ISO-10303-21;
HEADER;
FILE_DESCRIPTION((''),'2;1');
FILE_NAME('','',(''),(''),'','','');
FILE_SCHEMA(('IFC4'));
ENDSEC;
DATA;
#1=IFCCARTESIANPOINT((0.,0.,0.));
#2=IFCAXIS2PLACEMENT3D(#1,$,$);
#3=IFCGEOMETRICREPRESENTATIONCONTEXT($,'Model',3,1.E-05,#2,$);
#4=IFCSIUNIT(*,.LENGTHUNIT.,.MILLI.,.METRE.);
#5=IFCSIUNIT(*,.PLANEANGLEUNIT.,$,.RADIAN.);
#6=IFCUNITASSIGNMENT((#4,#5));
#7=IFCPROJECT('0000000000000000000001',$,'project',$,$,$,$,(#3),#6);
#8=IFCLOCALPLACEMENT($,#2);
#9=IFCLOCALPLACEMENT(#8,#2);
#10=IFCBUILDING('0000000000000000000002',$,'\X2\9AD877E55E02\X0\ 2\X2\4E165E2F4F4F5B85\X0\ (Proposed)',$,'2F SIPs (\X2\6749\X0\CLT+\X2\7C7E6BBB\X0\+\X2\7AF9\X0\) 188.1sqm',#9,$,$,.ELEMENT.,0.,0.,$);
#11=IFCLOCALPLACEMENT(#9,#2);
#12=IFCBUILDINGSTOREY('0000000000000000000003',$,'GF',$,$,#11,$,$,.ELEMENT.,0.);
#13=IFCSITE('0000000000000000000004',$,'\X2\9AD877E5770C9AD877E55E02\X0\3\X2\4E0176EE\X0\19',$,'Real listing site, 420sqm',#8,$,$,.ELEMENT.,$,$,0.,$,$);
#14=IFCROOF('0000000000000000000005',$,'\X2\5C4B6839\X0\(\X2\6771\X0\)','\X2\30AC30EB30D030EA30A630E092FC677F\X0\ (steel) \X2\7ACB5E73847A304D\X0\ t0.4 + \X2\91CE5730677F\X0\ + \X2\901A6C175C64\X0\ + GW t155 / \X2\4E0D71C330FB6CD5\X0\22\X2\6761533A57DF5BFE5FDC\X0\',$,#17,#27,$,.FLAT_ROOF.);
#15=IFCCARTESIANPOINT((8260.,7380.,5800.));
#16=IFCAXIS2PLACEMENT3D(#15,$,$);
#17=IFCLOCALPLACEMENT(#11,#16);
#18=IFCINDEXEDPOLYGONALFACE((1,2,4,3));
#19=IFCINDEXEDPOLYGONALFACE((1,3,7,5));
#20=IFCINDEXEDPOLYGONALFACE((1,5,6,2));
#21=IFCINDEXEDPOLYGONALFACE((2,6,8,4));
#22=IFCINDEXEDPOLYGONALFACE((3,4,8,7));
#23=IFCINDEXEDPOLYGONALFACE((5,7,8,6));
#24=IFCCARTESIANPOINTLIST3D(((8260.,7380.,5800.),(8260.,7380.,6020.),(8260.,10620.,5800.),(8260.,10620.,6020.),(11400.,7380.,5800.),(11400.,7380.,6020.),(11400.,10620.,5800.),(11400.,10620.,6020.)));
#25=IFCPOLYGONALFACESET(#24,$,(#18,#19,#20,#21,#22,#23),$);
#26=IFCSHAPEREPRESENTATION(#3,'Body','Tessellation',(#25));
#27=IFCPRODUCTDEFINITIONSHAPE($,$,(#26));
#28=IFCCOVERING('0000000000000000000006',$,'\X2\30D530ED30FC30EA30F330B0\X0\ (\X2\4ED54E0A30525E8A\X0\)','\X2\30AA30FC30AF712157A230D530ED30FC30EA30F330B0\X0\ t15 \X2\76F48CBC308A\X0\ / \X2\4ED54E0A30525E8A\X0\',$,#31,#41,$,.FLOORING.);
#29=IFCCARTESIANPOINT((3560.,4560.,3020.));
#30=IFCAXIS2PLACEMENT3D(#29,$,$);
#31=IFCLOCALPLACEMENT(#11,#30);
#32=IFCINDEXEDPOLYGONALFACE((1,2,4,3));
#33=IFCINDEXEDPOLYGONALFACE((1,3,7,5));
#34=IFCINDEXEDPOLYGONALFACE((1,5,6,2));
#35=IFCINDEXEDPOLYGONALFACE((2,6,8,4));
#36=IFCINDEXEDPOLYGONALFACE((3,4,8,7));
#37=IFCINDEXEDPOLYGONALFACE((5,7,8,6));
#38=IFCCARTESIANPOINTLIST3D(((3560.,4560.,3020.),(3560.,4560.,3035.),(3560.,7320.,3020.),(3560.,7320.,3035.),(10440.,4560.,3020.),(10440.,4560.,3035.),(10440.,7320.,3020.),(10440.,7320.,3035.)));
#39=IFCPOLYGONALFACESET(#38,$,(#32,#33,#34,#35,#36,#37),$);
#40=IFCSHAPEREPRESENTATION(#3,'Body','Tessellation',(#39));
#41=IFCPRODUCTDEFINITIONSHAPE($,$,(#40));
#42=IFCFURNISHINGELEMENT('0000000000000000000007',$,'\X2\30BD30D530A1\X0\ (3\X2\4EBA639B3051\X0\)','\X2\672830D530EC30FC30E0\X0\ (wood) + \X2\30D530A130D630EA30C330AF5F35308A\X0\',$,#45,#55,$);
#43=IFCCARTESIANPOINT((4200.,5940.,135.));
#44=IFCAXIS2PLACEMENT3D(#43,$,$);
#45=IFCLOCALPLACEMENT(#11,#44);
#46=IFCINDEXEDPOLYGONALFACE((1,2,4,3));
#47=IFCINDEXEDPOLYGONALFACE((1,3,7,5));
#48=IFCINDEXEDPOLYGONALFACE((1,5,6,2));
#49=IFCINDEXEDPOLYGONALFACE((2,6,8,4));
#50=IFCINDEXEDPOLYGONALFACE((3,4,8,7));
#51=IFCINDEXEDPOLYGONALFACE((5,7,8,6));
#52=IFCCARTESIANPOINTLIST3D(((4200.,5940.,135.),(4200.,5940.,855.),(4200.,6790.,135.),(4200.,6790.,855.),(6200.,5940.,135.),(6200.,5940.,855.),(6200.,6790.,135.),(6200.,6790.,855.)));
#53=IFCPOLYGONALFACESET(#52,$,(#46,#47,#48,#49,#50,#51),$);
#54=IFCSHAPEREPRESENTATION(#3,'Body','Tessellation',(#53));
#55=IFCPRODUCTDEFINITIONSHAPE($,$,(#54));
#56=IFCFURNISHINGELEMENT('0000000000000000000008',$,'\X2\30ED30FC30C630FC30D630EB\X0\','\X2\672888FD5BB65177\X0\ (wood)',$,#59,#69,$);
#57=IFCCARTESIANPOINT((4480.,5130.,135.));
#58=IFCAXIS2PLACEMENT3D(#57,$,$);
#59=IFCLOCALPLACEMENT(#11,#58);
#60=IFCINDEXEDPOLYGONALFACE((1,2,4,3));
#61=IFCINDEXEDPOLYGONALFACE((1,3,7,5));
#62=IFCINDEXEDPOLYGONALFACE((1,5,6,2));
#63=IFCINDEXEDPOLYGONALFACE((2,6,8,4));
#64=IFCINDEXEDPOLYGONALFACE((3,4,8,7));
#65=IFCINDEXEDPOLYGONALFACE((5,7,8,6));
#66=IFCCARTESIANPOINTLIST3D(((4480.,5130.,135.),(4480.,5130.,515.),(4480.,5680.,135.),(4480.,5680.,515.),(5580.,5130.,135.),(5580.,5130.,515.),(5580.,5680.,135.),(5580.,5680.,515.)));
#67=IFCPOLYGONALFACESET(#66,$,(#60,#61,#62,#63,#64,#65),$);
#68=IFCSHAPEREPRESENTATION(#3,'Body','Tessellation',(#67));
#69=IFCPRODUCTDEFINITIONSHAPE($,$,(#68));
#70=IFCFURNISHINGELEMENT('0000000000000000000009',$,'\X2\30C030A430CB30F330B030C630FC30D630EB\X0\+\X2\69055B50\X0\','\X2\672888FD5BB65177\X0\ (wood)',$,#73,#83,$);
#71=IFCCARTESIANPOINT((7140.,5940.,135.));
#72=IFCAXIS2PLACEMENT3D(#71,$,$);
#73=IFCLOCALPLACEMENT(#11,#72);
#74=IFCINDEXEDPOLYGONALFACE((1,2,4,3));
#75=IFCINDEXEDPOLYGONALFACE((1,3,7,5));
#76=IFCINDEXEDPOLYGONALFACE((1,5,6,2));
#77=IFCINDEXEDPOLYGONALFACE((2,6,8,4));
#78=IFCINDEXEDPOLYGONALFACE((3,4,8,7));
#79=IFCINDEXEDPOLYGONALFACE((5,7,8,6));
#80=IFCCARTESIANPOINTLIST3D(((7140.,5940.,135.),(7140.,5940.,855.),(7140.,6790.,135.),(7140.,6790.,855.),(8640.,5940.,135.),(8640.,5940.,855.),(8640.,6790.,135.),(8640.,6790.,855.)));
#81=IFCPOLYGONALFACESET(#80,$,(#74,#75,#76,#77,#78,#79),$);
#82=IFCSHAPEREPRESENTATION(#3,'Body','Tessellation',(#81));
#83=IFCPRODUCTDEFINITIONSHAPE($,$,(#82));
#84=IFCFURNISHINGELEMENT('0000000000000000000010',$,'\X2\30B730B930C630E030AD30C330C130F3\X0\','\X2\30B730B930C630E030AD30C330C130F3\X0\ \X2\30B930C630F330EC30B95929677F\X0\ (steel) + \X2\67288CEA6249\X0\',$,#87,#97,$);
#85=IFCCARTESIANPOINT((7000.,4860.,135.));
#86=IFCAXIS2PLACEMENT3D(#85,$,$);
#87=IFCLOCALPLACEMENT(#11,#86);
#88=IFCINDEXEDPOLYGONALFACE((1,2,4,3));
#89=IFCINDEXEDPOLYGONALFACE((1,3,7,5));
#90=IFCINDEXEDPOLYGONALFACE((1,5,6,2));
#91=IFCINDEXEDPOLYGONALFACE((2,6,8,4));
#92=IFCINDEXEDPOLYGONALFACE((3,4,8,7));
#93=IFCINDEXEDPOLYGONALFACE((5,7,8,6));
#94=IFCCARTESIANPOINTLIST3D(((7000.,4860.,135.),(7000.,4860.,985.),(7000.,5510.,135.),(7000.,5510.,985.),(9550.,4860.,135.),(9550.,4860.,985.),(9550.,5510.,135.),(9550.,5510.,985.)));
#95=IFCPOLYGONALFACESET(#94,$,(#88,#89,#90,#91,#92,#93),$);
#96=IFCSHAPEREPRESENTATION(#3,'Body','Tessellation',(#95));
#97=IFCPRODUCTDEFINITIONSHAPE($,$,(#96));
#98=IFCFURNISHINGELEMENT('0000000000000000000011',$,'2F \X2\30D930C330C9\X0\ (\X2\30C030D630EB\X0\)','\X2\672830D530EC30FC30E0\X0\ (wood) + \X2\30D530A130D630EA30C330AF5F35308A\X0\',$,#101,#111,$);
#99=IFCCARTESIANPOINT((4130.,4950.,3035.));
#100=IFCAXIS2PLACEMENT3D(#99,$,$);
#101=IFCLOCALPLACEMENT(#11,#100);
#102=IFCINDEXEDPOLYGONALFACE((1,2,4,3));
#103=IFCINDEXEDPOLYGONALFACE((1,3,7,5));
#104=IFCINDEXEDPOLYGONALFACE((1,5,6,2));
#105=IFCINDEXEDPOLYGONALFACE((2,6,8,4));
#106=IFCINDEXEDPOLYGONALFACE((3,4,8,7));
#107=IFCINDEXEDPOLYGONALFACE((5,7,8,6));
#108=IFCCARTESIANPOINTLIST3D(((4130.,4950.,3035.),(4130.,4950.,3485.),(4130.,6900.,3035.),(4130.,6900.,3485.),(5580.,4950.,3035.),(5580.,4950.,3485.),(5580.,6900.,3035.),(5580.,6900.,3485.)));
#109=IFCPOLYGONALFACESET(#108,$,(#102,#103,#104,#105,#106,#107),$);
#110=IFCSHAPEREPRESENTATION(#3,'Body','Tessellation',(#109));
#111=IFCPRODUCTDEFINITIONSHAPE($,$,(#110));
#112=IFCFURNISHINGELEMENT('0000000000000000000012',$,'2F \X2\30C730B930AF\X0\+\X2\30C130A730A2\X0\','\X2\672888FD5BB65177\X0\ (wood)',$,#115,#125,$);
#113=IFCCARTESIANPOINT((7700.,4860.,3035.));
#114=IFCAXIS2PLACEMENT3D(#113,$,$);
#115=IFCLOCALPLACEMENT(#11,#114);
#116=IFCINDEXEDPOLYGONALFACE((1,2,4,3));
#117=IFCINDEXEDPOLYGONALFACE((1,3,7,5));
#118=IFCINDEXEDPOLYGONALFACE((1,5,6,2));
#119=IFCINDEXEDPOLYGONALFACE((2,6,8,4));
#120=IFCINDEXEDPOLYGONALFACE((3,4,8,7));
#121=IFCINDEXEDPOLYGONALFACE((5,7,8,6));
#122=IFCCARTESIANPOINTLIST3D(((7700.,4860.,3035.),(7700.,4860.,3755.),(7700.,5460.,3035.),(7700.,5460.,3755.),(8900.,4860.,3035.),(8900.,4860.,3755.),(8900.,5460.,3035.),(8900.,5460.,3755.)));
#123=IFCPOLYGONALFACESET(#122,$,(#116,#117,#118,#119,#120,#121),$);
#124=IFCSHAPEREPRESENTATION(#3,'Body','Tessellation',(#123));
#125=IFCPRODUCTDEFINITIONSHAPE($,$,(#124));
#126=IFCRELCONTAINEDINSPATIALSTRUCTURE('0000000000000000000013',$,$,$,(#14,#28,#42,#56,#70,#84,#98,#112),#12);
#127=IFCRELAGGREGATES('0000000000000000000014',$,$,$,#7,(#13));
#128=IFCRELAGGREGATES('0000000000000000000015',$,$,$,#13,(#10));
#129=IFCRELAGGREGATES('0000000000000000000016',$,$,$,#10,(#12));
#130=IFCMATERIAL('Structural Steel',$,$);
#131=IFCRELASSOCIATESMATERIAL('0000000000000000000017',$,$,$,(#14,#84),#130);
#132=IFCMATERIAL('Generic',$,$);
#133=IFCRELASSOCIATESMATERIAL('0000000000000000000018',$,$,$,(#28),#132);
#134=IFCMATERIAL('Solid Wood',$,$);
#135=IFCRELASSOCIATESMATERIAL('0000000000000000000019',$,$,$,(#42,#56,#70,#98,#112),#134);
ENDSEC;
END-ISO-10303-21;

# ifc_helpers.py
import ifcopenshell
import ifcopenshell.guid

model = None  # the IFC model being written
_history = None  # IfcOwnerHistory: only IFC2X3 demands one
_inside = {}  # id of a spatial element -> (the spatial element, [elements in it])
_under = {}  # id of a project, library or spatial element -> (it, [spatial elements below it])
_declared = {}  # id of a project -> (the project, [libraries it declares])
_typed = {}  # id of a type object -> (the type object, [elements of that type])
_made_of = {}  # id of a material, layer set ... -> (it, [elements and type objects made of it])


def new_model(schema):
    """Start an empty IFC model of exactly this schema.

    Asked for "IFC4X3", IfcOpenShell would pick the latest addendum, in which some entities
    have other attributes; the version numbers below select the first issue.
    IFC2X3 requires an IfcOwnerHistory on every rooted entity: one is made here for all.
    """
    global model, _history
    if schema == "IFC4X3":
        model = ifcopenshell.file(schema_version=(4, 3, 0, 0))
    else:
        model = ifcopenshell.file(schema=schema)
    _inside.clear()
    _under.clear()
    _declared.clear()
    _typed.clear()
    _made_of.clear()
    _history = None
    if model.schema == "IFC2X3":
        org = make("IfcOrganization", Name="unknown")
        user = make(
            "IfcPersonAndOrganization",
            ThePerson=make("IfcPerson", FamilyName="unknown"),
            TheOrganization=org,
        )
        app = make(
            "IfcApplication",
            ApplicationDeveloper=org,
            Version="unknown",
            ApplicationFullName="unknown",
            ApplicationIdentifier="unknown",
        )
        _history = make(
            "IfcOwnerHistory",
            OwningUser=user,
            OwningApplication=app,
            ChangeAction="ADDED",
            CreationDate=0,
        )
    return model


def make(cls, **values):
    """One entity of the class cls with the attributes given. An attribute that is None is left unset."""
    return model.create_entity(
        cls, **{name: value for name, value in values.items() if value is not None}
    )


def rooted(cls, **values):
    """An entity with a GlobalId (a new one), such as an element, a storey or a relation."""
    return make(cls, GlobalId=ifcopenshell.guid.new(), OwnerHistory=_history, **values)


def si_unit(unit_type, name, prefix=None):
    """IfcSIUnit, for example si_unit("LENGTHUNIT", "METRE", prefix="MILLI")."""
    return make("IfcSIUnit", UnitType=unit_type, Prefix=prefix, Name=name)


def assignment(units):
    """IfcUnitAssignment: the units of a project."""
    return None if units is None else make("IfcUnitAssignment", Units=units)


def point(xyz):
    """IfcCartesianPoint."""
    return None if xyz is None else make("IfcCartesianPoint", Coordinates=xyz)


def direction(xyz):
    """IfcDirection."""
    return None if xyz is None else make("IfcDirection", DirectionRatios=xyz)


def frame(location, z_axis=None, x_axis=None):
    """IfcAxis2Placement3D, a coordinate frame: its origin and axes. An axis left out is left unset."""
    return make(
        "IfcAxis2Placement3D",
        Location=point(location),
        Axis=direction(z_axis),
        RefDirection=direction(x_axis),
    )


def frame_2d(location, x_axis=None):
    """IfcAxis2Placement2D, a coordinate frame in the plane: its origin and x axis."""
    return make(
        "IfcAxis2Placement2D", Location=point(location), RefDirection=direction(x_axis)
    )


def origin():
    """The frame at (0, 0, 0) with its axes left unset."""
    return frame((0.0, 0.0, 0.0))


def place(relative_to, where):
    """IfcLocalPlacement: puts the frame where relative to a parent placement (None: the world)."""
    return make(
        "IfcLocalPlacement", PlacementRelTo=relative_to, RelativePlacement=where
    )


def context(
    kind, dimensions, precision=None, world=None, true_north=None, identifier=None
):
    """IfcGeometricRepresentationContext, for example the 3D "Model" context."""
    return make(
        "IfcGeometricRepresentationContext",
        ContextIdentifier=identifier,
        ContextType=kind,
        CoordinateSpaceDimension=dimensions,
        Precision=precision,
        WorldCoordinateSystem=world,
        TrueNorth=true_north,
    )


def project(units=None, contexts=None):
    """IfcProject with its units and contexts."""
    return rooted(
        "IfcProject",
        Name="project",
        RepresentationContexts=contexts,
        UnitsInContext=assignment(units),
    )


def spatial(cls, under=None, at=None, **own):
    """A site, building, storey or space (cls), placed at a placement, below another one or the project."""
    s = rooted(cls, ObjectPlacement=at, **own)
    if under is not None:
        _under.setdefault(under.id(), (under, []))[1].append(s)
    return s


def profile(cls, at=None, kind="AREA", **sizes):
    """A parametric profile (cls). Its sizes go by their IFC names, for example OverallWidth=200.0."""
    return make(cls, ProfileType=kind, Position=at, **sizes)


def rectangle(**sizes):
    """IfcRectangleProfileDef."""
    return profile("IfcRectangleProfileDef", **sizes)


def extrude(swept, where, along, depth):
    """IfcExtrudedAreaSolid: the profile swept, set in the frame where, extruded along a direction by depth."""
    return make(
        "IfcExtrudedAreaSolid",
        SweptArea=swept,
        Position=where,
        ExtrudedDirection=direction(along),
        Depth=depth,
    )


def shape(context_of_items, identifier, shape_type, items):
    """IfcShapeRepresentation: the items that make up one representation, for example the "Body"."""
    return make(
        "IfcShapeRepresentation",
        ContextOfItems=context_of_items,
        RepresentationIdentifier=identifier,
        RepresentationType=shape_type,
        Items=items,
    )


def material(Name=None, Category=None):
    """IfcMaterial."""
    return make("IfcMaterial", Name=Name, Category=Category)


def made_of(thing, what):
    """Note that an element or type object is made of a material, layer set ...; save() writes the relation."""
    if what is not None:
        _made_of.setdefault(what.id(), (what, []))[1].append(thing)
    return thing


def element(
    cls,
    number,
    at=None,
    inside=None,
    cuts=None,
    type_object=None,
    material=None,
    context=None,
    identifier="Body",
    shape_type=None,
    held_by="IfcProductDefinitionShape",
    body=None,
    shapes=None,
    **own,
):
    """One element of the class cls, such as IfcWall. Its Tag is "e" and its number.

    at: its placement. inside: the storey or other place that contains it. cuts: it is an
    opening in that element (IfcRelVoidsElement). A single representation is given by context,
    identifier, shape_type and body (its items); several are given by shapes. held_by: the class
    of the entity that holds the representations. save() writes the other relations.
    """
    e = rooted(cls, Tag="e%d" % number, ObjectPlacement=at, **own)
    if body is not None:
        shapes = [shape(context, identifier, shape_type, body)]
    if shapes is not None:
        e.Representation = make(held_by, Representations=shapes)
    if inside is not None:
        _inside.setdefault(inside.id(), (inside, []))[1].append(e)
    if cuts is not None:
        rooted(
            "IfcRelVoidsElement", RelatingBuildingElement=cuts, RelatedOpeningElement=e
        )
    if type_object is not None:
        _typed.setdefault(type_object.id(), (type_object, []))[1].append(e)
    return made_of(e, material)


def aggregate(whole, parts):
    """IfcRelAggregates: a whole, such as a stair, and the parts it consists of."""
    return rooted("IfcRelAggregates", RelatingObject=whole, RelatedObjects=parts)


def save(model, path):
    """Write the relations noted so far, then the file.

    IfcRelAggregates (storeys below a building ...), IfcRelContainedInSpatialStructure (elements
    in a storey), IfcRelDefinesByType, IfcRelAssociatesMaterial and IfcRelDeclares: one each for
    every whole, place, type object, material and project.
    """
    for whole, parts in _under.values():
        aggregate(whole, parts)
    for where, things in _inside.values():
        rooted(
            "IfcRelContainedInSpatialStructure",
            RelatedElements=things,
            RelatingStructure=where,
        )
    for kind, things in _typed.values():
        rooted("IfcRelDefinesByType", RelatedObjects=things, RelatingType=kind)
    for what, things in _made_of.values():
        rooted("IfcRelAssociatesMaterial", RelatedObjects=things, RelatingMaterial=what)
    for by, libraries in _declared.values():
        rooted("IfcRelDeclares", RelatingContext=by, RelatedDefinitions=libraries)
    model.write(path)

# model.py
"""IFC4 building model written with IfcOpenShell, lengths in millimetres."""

from ifc_helpers import new_model, si_unit, frame, frame_2d, origin, place, context, project, spatial, rectangle, extrude, material, element, save


model = new_model("IFC4")

# Units and contexts
model_context = context("Model", 3, precision=1e-05, world=origin())
ifc_project = project(units=[si_unit("LENGTHUNIT", "METRE", prefix="MILLI"), si_unit("PLANEANGLEUNIT", "RADIAN")], contexts=[model_context])

# Site, building, storey
site_placement = place(None, origin())
site = spatial("IfcSite", under=ifc_project, at=site_placement, Name="高知県高知市3丁目19", ObjectType="Real listing site, 420sqm", CompositionType="ELEMENT", RefElevation=0.0)
building_placement = place(site_placement, origin())
building = spatial("IfcBuilding", under=site, at=building_placement, Name="高知市 2世帯住宅 (Proposed)", ObjectType="2F SIPs (杉CLT+籾殻+竹) 188.1sqm", CompositionType="ELEMENT", ElevationOfRefHeight=0.0, ElevationOfTerrain=0.0)
storey_placement = place(building_placement, origin())
storey = spatial("IfcBuildingStorey", under=building, at=storey_placement, Name="GF", CompositionType="ELEMENT", Elevation=0.0)

# Shared definitions
ifc_material_1 = material(Name="Solid Wood")

# Shared definitions
ifc_material_2 = material(Name="Generic")

# Roof
ifc_material_3 = material(Name="Structural Steel")
roof_placement = place(storey_placement, frame((8260.0, 7380.0, 5800.0)))
element("IfcRoof", 1, at=roof_placement, inside=storey, material=ifc_material_3, Name="屋根(東)", Description="ガルバリウム鋼板 (steel) 立平葺き t0.4 + 野地板 + 通気層 + GW t155 / 不燃・法22条区域対応", PredefinedType="FLAT_ROOF", context=model_context, shape_type="SweptSolid", body=[
    extrude(rectangle(XDim=3140.0, YDim=3240.0, at=frame_2d((1570.0, 1620.0))), frame((8260.0, 7380.0, 5800.0)), (0.0, 0.0, 1.0), 220.0),
])

# Covering
covering_placement = place(storey_placement, frame((3560.0, 4560.0, 3020.0)))
element("IfcCovering", 2, at=covering_placement, inside=storey, material=ifc_material_2, Name="フローリング (仕上げ床)", Description="オーク無垢フローリング t15 直貼り / 仕上げ床", PredefinedType="FLOORING", context=model_context, shape_type="SweptSolid", body=[
    extrude(rectangle(XDim=6880.0, YDim=2760.0, at=frame_2d((3440.0, 1380.0))), frame((3560.0, 4560.0, 3020.0)), (0.0, 0.0, 1.0), 15.0),
])

# Furnishing elements
furnishing_1_placement = place(storey_placement, frame((4200.0, 5940.0, 135.0)))
element("IfcFurnishingElement", 3, at=furnishing_1_placement, inside=storey, material=ifc_material_1, Name="ソファ (3人掛け)", Description="木フレーム (wood) + ファブリック張り", context=model_context, shape_type="SweptSolid", body=[
    extrude(rectangle(XDim=2000.0, YDim=850.0, at=frame_2d((1000.0, 425.0))), frame((4200.0, 5940.0, 135.0)), (0.0, 0.0, 1.0), 720.0),
])
furnishing_2_placement = place(storey_placement, frame((4480.0, 5130.0, 135.0)))
element("IfcFurnishingElement", 4, at=furnishing_2_placement, inside=storey, material=ifc_material_1, Name="ローテーブル", Description="木製家具 (wood)", context=model_context, shape_type="SweptSolid", body=[
    extrude(rectangle(XDim=1100.0, YDim=550.0, at=frame_2d((550.0, 275.0))), frame((4480.0, 5130.0, 135.0)), (0.0, 0.0, 1.0), 380.0),
])
furnishing_3_placement = place(storey_placement, frame((7140.0, 5940.0, 135.0)))
element("IfcFurnishingElement", 5, at=furnishing_3_placement, inside=storey, material=ifc_material_1, Name="ダイニングテーブル+椅子", Description="木製家具 (wood)", context=model_context, shape_type="SweptSolid", body=[
    extrude(rectangle(XDim=1500.0, YDim=850.0, at=frame_2d((750.0, 425.0))), frame((7140.0, 5940.0, 135.0)), (0.0, 0.0, 1.0), 720.0),
])
furnishing_4_placement = place(storey_placement, frame((7000.0, 4860.0, 135.0)))
element("IfcFurnishingElement", 6, at=furnishing_4_placement, inside=storey, material=ifc_material_3, Name="システムキッチン", Description="システムキッチン ステンレス天板 (steel) + 木質扉", context=model_context, shape_type="SweptSolid", body=[
    extrude(rectangle(XDim=2550.0, YDim=650.0, at=frame_2d((1275.0, 325.0))), frame((7000.0, 4860.0, 135.0)), (0.0, 0.0, 1.0), 850.0),
])
furnishing_5_placement = place(storey_placement, frame((4130.0, 4950.0, 3035.0)))
element("IfcFurnishingElement", 7, at=furnishing_5_placement, inside=storey, material=ifc_material_1, Name="2F ベッド (ダブル)", Description="木フレーム (wood) + ファブリック張り", context=model_context, shape_type="SweptSolid", body=[
    extrude(rectangle(XDim=1450.0, YDim=1950.0, at=frame_2d((725.0, 975.0))), frame((4130.0, 4950.0, 3035.0)), (0.0, 0.0, 1.0), 450.0),
])
furnishing_6_placement = place(storey_placement, frame((7700.0, 4860.0, 3035.0)))
element("IfcFurnishingElement", 8, at=furnishing_6_placement, inside=storey, material=ifc_material_1, Name="2F デスク+チェア", Description="木製家具 (wood)", context=model_context, shape_type="SweptSolid", body=[
    extrude(rectangle(XDim=1200.0, YDim=600.0, at=frame_2d((600.0, 300.0))), frame((7700.0, 4860.0, 3035.0)), (0.0, 0.0, 1.0), 720.0),
])

save(model, "model.ifc")
